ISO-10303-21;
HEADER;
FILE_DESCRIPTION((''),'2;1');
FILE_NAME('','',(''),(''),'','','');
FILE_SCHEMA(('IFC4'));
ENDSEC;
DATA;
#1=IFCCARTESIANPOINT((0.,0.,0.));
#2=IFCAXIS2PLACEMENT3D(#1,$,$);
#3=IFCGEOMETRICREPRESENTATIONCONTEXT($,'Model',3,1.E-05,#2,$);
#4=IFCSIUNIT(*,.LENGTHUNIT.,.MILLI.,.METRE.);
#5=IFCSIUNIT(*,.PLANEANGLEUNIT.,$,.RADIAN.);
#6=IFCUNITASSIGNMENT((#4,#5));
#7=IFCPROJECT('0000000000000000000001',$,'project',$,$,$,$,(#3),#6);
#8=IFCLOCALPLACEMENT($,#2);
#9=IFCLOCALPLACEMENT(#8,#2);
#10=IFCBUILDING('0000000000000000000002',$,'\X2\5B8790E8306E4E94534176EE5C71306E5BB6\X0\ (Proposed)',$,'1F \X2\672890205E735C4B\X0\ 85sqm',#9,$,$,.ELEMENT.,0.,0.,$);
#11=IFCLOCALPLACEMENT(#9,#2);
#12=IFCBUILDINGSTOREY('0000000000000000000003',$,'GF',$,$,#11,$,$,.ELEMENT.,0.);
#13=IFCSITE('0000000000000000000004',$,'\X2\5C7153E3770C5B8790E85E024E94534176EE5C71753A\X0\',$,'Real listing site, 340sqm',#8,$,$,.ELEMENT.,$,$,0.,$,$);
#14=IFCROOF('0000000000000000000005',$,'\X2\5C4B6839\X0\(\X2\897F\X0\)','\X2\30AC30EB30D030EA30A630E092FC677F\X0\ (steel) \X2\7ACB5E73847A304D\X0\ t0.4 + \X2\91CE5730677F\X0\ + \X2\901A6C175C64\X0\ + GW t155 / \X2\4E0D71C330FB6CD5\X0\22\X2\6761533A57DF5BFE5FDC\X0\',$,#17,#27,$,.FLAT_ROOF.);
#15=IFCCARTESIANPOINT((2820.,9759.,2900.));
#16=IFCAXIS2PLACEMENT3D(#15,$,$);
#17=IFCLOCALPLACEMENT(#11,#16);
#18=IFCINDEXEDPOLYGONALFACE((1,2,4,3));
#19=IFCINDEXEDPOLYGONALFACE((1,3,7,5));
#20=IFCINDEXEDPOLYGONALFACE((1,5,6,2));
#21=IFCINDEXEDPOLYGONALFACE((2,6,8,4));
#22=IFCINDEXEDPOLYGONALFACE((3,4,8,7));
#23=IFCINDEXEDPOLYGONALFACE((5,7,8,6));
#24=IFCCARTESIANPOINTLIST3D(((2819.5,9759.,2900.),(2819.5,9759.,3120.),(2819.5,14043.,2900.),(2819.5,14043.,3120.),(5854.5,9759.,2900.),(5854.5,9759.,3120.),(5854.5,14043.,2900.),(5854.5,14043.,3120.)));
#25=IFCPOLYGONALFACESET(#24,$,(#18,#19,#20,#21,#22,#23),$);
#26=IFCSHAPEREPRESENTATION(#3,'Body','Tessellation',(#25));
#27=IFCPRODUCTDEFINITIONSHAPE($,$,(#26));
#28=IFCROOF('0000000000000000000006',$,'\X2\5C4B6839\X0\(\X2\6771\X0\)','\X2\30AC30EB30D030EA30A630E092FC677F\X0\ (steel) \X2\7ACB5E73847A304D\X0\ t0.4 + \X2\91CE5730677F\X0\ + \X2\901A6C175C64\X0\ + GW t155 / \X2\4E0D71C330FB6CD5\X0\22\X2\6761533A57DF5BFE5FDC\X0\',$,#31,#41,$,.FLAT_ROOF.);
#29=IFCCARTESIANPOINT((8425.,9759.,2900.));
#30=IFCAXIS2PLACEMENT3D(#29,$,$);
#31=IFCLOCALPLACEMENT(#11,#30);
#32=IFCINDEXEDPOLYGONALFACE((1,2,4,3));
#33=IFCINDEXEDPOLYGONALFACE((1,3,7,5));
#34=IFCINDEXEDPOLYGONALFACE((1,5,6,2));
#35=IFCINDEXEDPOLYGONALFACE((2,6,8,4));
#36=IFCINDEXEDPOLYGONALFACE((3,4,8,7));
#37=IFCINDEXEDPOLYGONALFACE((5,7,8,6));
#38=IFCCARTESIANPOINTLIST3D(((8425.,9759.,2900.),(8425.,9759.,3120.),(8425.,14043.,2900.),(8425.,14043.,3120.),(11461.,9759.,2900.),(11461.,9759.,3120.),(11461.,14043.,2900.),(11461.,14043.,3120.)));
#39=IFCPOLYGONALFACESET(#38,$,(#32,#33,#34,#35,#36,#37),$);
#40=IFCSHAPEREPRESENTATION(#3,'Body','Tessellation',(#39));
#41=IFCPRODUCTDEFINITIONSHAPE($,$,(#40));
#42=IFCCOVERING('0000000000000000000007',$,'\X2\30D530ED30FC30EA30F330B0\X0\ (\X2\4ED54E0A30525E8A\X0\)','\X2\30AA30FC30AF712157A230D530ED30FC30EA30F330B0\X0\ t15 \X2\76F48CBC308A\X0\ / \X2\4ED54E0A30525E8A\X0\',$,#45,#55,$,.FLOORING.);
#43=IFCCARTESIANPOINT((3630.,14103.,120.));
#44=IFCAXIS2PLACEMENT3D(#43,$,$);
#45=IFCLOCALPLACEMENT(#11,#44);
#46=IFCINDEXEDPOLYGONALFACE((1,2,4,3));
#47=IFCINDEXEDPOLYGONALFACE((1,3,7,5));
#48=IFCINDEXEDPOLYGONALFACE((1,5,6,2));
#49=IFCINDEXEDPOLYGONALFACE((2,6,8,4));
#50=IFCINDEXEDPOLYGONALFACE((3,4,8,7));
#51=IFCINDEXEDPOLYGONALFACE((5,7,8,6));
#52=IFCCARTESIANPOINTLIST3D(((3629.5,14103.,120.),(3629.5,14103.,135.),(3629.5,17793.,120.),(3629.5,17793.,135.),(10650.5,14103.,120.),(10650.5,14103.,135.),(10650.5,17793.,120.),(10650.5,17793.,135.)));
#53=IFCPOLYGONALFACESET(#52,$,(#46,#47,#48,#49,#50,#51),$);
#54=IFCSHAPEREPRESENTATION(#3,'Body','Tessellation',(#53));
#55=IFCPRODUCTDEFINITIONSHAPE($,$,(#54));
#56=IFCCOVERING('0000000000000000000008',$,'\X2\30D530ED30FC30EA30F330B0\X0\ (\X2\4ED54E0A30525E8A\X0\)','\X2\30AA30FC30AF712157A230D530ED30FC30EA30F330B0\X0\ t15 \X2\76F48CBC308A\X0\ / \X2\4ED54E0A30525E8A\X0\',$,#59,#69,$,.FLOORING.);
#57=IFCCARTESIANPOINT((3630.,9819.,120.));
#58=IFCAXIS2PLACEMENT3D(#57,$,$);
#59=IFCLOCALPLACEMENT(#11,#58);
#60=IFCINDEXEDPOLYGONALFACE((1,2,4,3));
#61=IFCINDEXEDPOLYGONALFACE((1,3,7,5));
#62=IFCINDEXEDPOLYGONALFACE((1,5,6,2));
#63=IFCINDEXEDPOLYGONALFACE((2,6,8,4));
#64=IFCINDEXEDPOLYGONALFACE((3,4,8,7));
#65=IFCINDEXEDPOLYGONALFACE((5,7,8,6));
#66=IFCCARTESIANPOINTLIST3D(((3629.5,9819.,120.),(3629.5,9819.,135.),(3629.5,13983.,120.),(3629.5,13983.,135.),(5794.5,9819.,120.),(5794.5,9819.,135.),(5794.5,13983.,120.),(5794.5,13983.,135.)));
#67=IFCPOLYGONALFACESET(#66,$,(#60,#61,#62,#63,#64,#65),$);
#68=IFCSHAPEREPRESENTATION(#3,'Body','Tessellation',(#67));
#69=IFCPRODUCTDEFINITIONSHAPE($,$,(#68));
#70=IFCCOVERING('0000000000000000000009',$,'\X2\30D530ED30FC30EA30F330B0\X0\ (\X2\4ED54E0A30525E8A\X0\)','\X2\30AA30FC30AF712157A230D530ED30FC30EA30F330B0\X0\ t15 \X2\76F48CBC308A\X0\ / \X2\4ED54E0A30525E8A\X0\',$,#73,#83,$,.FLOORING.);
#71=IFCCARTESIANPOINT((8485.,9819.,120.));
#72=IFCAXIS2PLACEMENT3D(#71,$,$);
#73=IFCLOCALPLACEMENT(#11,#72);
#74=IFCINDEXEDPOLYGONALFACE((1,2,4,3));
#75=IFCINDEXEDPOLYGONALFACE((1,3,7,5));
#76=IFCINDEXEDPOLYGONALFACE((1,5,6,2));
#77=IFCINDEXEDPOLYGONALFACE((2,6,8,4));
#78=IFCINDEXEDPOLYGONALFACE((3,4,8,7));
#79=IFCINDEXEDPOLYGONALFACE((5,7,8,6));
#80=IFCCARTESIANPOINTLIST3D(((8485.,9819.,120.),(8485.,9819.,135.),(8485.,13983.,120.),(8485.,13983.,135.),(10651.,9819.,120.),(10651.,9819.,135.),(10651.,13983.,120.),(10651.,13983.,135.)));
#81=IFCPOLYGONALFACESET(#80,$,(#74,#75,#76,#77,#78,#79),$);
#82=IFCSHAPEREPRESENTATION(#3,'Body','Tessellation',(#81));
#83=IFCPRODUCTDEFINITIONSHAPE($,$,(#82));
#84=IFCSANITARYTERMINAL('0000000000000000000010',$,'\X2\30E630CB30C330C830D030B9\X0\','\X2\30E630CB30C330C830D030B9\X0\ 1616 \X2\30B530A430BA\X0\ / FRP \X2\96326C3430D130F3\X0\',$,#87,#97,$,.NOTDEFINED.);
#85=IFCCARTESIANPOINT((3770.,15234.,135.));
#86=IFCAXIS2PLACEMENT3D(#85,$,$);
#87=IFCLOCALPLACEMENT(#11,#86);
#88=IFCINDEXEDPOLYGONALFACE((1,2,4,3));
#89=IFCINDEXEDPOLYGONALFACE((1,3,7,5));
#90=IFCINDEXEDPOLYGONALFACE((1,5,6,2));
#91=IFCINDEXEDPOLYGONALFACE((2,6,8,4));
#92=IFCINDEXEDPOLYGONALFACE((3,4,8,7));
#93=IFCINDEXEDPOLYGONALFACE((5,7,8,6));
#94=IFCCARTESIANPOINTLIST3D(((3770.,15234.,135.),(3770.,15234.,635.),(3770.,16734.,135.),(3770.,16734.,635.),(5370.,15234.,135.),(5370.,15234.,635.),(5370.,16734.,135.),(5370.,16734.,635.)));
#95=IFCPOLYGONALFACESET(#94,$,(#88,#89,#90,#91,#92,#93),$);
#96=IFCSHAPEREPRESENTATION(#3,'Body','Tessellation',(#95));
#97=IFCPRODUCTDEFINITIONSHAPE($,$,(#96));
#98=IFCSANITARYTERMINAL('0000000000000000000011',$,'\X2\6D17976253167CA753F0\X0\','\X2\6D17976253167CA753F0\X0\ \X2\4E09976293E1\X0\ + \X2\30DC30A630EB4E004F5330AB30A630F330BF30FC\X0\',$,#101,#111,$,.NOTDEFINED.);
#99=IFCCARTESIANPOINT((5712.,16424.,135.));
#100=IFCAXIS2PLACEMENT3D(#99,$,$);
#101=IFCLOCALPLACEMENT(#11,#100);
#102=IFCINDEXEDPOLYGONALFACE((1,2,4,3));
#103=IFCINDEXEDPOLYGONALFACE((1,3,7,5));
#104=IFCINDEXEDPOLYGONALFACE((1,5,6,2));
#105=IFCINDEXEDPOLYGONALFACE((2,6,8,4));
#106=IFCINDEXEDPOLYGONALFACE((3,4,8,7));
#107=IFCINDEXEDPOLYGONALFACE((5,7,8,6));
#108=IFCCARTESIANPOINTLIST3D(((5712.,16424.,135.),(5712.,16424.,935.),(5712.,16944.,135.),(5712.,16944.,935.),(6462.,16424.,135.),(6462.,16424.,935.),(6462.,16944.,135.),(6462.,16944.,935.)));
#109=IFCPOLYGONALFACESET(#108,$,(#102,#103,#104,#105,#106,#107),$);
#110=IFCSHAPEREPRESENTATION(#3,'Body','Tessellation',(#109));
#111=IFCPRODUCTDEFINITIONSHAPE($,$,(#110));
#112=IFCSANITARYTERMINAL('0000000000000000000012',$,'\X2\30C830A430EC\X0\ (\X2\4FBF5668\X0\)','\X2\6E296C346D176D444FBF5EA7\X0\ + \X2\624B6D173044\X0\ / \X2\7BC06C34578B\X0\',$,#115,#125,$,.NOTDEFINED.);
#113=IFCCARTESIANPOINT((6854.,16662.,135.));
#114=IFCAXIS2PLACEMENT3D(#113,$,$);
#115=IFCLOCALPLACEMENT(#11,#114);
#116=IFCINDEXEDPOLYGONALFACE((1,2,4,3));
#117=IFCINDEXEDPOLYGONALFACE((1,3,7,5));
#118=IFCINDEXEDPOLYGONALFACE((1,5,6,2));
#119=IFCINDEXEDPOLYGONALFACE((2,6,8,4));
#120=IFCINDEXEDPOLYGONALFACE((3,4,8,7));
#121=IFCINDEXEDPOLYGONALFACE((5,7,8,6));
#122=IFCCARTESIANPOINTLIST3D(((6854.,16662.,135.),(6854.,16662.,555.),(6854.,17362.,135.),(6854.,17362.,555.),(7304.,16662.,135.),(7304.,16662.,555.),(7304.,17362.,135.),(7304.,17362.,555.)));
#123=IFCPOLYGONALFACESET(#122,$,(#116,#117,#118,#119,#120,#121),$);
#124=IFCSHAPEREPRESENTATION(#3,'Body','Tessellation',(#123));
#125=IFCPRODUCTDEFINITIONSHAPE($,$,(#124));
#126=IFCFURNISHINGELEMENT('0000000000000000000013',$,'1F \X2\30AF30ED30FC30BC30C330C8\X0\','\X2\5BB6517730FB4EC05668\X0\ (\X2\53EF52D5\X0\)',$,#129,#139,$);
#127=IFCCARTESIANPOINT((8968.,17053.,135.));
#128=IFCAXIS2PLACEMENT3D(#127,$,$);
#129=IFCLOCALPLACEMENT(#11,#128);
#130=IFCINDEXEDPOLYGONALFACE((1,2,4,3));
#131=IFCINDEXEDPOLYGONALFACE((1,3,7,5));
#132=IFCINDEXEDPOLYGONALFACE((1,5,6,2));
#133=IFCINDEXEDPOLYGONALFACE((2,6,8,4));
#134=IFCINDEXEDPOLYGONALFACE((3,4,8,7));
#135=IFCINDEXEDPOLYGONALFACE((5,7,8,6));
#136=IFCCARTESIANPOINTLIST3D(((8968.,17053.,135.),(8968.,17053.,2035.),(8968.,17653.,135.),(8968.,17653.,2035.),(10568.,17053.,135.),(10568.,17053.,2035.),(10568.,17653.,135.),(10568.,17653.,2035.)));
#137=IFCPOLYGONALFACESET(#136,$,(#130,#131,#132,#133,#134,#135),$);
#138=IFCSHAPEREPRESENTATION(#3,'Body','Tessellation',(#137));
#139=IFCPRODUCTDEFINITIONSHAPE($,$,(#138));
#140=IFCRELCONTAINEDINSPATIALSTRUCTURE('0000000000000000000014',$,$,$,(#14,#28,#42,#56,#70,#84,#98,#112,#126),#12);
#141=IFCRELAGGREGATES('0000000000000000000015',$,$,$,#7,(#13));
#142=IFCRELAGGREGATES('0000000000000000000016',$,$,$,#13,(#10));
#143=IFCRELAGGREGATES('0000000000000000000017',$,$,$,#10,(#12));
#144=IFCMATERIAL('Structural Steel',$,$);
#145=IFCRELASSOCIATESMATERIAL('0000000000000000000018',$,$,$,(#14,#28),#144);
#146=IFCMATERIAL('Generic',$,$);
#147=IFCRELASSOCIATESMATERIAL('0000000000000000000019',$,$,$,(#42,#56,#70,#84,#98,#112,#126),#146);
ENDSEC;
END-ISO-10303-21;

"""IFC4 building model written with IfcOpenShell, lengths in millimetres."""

from ifc_helpers import new_model, si_unit, frame, frame_2d, origin, place, context, project, spatial, rectangle, extrude, material, element, save


model = new_model("IFC4")

# Units and contexts
model_context = context("Model", 3, precision=1e-05, world=origin())
ifc_project = project(units=[si_unit("LENGTHUNIT", "METRE", prefix="MILLI"), si_unit("PLANEANGLEUNIT", "RADIAN")], contexts=[model_context])

# Site, building, storey
site_placement = place(None, origin())
site = spatial("IfcSite", under=ifc_project, at=site_placement, Name="山口県宇部市五十目山町", ObjectType="Real listing site, 340sqm", CompositionType="ELEMENT", RefElevation=0.0)
building_placement = place(site_placement, origin())
building = spatial("IfcBuilding", under=site, at=building_placement, Name="宇部の五十目山の家 (Proposed)", ObjectType="1F 木造平屋 85sqm", CompositionType="ELEMENT", ElevationOfRefHeight=0.0, ElevationOfTerrain=0.0)
storey_placement = place(building_placement, origin())
storey = spatial("IfcBuildingStorey", under=building, at=storey_placement, Name="GF", CompositionType="ELEMENT", Elevation=0.0)

# Roofs
ifc_material_1 = material(Name="Structural Steel")
roof_1_placement = place(storey_placement, frame((2820.0, 9759.0, 2900.0)))
element("IfcRoof", 1, at=roof_1_placement, inside=storey, material=ifc_material_1, Name="屋根(西)", Description="ガルバリウム鋼板 (steel) 立平葺き t0.4 + 野地板 + 通気層 + GW t155 / 不燃・法22条区域対応", PredefinedType="FLAT_ROOF", context=model_context, shape_type="SweptSolid", body=[
    extrude(rectangle(XDim=3035.0, YDim=4284.0, at=frame_2d((1517.0, 2142.0))), frame((2820.0, 9759.0, 2900.0)), (0.0, 0.0, 1.0), 220.0),
])
roof_2_placement = place(storey_placement, frame((8425.0, 9759.0, 2900.0)))
element("IfcRoof", 2, at=roof_2_placement, inside=storey, material=ifc_material_1, Name="屋根(東)", Description="ガルバリウム鋼板 (steel) 立平葺き t0.4 + 野地板 + 通気層 + GW t155 / 不燃・法22条区域対応", PredefinedType="FLAT_ROOF", context=model_context, shape_type="SweptSolid", body=[
    extrude(rectangle(XDim=3036.0, YDim=4284.0, at=frame_2d((1518.0, 2142.0))), frame((8425.0, 9759.0, 2900.0)), (0.0, 0.0, 1.0), 220.0),
])

# Coverings
ifc_material_2 = material(Name="Generic")
covering_1_placement = place(storey_placement, frame((3630.0, 14103.0, 120.0)))
element("IfcCovering", 3, at=covering_1_placement, inside=storey, material=ifc_material_2, Name="フローリング (仕上げ床)", Description="オーク無垢フローリング t15 直貼り / 仕上げ床", PredefinedType="FLOORING", context=model_context, shape_type="SweptSolid", body=[
    extrude(rectangle(XDim=7021.0, YDim=3690.0, at=frame_2d((3510.0, 1845.0))), frame((3630.0, 14103.0, 120.0)), (0.0, 0.0, 1.0), 15.0),
])
covering_2_placement = place(storey_placement, frame((3630.0, 9819.0, 120.0)))
element("IfcCovering", 4, at=covering_2_placement, inside=storey, material=ifc_material_2, Name="フローリング (仕上げ床)", Description="オーク無垢フローリング t15 直貼り / 仕上げ床", PredefinedType="FLOORING", context=model_context, shape_type="SweptSolid", body=[
    extrude(rectangle(XDim=2165.0, YDim=4164.0, at=frame_2d((1082.0, 2082.0))), frame((3630.0, 9819.0, 120.0)), (0.0, 0.0, 1.0), 15.0),
])
covering_3_placement = place(storey_placement, frame((8485.0, 9819.0, 120.0)))
element("IfcCovering", 5, at=covering_3_placement, inside=storey, material=ifc_material_2, Name="フローリング (仕上げ床)", Description="オーク無垢フローリング t15 直貼り / 仕上げ床", PredefinedType="FLOORING", context=model_context, shape_type="SweptSolid", body=[
    extrude(rectangle(XDim=2166.0, YDim=4164.0, at=frame_2d((1083.0, 2082.0))), frame((8485.0, 9819.0, 120.0)), (0.0, 0.0, 1.0), 15.0),
])

# Sanitary terminals
sanitary_terminal_1_placement = place(storey_placement, frame((3770.0, 15234.0, 135.0)))
element("IfcSanitaryTerminal", 6, at=sanitary_terminal_1_placement, inside=storey, material=ifc_material_2, Name="ユニットバス", Description="ユニットバス 1616 サイズ / FRP 防水パン", PredefinedType="NOTDEFINED", context=model_context, shape_type="SweptSolid", body=[
    extrude(rectangle(XDim=1600.0, YDim=1500.0, at=frame_2d((800.0, 750.0))), frame((3770.0, 15234.0, 135.0)), (0.0, 0.0, 1.0), 500.0),
])
sanitary_terminal_2_placement = place(storey_placement, frame((5712.0, 16424.0, 135.0)))
element("IfcSanitaryTerminal", 7, at=sanitary_terminal_2_placement, inside=storey, material=ifc_material_2, Name="洗面化粧台", Description="洗面化粧台 三面鏡 + ボウル一体カウンター", PredefinedType="NOTDEFINED", context=model_context, shape_type="SweptSolid", body=[
    extrude(rectangle(XDim=750.0, YDim=520.0, at=frame_2d((375.0, 260.0))), frame((5712.0, 16424.0, 135.0)), (0.0, 0.0, 1.0), 800.0),
])
sanitary_terminal_3_placement = place(storey_placement, frame((6854.0, 16662.0, 135.0)))
element("IfcSanitaryTerminal", 8, at=sanitary_terminal_3_placement, inside=storey, material=ifc_material_2, Name="トイレ (便器)", Description="温水洗浄便座 + 手洗い / 節水型", PredefinedType="NOTDEFINED", context=model_context, shape_type="SweptSolid", body=[
    extrude(rectangle(XDim=450.0, YDim=700.0, at=frame_2d((225.0, 350.0))), frame((6854.0, 16662.0, 135.0)), (0.0, 0.0, 1.0), 420.0),
])

# Furnishing element
furnishing_placement = place(storey_placement, frame((8968.0, 17053.0, 135.0)))
element("IfcFurnishingElement", 9, at=furnishing_placement, inside=storey, material=ifc_material_2, Name="1F クローゼット", Description="家具・什器 (可動)", context=model_context, shape_type="SweptSolid", body=[
    extrude(rectangle(XDim=1600.0, YDim=600.0, at=frame_2d((800.0, 300.0))), frame((8968.0, 17053.0, 135.0)), (0.0, 0.0, 1.0), 1900.0),
])

save(model, "model.ifc")
